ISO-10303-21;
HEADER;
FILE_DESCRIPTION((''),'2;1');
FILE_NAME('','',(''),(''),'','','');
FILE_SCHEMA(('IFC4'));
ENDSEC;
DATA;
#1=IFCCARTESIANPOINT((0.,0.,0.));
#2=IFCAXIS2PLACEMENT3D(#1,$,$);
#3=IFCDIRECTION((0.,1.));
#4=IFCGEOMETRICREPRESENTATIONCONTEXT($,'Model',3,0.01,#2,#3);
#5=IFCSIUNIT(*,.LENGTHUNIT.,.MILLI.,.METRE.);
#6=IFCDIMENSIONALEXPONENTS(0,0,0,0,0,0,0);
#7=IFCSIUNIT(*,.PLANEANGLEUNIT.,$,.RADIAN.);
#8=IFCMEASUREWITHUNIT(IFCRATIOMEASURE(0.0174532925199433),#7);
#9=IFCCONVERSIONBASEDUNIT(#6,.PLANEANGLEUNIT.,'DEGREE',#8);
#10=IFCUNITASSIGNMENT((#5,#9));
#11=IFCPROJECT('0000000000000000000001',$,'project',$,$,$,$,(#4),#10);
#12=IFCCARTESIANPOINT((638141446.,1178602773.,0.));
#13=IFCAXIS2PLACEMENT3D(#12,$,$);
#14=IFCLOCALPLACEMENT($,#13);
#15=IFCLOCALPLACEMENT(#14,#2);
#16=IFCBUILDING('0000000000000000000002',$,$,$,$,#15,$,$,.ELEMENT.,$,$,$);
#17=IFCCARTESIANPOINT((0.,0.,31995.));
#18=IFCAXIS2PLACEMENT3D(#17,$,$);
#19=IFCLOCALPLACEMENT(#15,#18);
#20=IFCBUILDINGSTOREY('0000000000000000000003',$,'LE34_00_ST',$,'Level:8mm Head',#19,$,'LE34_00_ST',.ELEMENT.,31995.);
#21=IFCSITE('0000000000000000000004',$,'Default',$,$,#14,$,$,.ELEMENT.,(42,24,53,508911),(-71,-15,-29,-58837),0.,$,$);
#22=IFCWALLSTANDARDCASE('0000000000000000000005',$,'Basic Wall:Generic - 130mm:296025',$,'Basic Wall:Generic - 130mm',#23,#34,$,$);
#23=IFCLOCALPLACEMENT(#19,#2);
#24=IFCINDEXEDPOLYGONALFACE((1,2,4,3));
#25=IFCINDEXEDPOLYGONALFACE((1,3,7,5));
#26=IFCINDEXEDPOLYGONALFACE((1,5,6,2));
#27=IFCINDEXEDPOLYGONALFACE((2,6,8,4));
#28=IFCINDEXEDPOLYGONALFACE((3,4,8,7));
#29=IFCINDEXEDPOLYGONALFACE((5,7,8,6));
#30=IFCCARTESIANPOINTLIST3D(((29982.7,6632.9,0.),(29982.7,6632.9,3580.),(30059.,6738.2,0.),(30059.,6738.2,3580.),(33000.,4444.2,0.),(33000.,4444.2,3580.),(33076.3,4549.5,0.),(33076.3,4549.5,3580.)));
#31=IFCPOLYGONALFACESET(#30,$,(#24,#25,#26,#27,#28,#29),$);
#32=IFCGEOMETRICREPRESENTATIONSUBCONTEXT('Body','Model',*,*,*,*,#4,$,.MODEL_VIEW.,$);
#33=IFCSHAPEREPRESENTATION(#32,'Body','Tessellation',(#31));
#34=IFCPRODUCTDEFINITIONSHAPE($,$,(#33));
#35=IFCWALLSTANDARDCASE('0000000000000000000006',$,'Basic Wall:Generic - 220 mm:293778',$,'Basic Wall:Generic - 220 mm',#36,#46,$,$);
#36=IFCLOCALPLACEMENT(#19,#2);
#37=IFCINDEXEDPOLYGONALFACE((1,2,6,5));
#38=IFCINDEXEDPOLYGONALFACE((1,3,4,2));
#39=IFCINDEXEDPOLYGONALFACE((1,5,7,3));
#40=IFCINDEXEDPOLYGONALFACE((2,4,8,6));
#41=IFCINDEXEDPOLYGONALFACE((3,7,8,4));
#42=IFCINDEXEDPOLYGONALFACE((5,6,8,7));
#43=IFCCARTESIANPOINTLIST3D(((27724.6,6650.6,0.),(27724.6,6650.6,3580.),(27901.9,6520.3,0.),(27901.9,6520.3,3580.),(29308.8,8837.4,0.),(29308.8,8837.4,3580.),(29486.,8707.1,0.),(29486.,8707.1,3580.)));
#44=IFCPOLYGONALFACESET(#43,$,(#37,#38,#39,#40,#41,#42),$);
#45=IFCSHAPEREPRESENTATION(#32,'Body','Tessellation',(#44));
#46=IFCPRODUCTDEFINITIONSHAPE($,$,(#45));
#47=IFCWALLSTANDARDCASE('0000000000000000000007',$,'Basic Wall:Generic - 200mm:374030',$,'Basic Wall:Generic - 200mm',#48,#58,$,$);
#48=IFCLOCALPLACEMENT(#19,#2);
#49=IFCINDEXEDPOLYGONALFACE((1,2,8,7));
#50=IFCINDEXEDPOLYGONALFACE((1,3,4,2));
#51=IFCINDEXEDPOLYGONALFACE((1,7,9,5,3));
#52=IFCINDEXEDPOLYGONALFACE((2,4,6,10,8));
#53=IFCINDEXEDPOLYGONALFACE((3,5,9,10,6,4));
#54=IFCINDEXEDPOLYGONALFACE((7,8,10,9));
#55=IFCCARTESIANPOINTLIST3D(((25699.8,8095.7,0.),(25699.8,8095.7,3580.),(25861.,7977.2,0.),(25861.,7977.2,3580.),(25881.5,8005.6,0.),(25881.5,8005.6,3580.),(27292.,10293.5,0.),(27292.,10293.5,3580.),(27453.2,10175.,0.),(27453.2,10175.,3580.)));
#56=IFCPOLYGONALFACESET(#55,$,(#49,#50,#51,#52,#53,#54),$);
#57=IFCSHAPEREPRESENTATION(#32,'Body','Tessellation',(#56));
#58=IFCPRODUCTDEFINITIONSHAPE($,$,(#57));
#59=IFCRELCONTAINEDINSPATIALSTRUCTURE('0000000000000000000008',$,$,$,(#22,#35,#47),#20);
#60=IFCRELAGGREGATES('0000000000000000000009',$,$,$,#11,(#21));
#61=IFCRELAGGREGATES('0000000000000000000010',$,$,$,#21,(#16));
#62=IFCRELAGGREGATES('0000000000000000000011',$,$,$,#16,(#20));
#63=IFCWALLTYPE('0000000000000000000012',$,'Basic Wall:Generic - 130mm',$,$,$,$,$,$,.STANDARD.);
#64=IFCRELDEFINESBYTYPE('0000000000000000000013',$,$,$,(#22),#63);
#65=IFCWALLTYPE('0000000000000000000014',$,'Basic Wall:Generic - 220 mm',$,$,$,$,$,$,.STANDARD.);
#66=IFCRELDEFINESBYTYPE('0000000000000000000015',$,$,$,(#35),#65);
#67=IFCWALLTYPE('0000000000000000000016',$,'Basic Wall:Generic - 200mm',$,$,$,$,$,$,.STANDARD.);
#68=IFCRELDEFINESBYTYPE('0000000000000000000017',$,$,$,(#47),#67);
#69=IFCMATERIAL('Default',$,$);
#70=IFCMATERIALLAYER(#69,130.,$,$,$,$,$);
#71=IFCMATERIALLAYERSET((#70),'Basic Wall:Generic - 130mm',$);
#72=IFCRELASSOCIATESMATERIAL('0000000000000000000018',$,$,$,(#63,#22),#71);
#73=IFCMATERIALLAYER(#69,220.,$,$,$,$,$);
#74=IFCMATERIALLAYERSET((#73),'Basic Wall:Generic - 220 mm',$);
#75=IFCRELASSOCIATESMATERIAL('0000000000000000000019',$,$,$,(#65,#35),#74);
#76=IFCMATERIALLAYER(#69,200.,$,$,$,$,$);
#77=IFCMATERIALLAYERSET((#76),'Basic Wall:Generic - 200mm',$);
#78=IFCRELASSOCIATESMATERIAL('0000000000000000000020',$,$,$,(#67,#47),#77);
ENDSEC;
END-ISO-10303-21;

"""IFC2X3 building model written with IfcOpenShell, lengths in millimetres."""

from ifc_helpers import new_model, entity, si_unit, converted_unit, direction, frame, origin, place, context, subcontext, project, spatial, polyline, outline, extrude, material, layer, layer_set, layer_usage, type_object, element, save


model = new_model("IFC2X3")

# Units and contexts
model_context = context("Model", 3, precision=0.01, world=origin(), true_north=direction((0.0, 1.0)))
body_context = subcontext(model_context, "Body", "Model", "MODEL_VIEW")
ifc_project = project(units=[si_unit("LENGTHUNIT", "METRE", prefix="MILLI"), converted_unit("PLANEANGLEUNIT", "DEGREE", entity("IfcRatioMeasure", 0.0174532925199433), si_unit("PLANEANGLEUNIT", "RADIAN"), dimensions=[0, 0, 0, 0, 0, 0, 0])], contexts=[model_context])

# Site, building, storey
site_placement = place(None, frame((638141446.0, 1178602773.0, 0.0)))
site = spatial("IfcSite", under=ifc_project, at=site_placement, Name="Default", CompositionType="ELEMENT", RefLatitude=(42, 24, 53, 508911), RefLongitude=(-71, -15, -29, -58837), RefElevation=0.0)
building_placement = place(site_placement, origin())
building = spatial("IfcBuilding", under=site, at=building_placement, CompositionType="ELEMENT")
storey_placement = place(building_placement, frame((0.0, 0.0, 31995.0)))
storey = spatial("IfcBuildingStorey", under=building, at=storey_placement, Name="LE34_00_ST", ObjectType="Level:8mm Head", LongName="LE34_00_ST", CompositionType="ELEMENT", Elevation=31995.0)

# Walls
ifc_material_1 = material(Name="Default")
ifc_layer_1 = layer(ifc_material_1, 130.0)
ifc_layer_set_1 = layer_set([ifc_layer_1], Name="Basic Wall:Generic - 130mm")
ifc_layer_usage_1 = layer_usage(ifc_layer_set_1, "AXIS2", "NEGATIVE", 65.0)
wall_type_1 = type_object("IfcWallType", Name="Basic Wall:Generic - 130mm", PredefinedType="STANDARD", material=ifc_layer_set_1)
wall_1_placement = place(storey_placement, frame((30020.8, 6685.5, 0.0), z_axis=(0.0, 0.0, 1.0), x_axis=(0.809468, -0.587164, 0.0)))
element("IfcWallStandardCase", 1, at=wall_1_placement, inside=storey, type_object=wall_type_1, material=ifc_layer_usage_1, Name="Basic Wall:Generic - 130mm:296025", ObjectType="Basic Wall:Generic - 130mm", context=body_context, shape_type="SweptSolid", body=[
    extrude(outline(polyline([(3727.5, -65.0), (3727.5, 65.0), (0.0, 65.0), (0.1, -65.0), (3727.5, -65.0)])), origin(), (0.0, 0.0, 1.0), 3580.0),
])
ifc_layer_2 = layer(ifc_material_1, 220.0)
ifc_layer_set_2 = layer_set([ifc_layer_2], Name="Basic Wall:Generic - 220 mm")
ifc_layer_usage_2 = layer_usage(ifc_layer_set_2, "AXIS2", "POSITIVE", -110.0)
wall_type_2 = type_object("IfcWallType", Name="Basic Wall:Generic - 220 mm", PredefinedType="STANDARD", material=ifc_layer_set_2)
wall_2_placement = place(storey_placement, frame((27812.8, 6584.9, 0.0), z_axis=(0.0, 0.0, 1.0), x_axis=(0.586669, 0.809827, 0.0)))
element("IfcWallStandardCase", 2, at=wall_2_placement, inside=storey, type_object=wall_type_2, material=ifc_layer_usage_2, Name="Basic Wall:Generic - 220 mm:293778", ObjectType="Basic Wall:Generic - 220 mm", context=body_context, shape_type="SweptSolid", body=[
    extrude(outline(polyline([(2700.3, -110.0), (2701.8, 110.0), (1.5, 110.0), (0.0, -110.0), (2700.3, -110.0)])), origin(), (0.0, 0.0, 1.0), 3580.0),
])

# Wall
ifc_layer_3 = layer(ifc_material_1, 200.0)
ifc_layer_set_3 = layer_set([ifc_layer_3], Name="Basic Wall:Generic - 200mm")
ifc_layer_usage_3 = layer_usage(ifc_layer_set_3, "AXIS2", "NEGATIVE", 100.0)
wall_type_3 = type_object("IfcWallType", Name="Basic Wall:Generic - 200mm", PredefinedType="STANDARD", material=ifc_layer_set_3)
wall_3_placement = place(storey_placement, frame((25780.0, 8035.9, 0.0), z_axis=(0.0, 0.0, 1.0), x_axis=(0.586669, 0.809827, 0.0)))
element("IfcWallStandardCase", 3, at=wall_3_placement, inside=storey, type_object=wall_type_3, material=ifc_layer_usage_3, Name="Basic Wall:Generic - 200mm:374030", ObjectType="Basic Wall:Generic - 200mm", context=body_context, shape_type="SweptSolid", body=[
    extrude(outline(polyline([(2713.9, -100.0), (2715.3, 100.0), (1.4, 100.0), (0.0, -100.0), (35.0, -100.0), (2713.9, -100.0)])), origin(), (0.0, 0.0, 1.0), 3580.0),
])

save(model, "model.ifc")
